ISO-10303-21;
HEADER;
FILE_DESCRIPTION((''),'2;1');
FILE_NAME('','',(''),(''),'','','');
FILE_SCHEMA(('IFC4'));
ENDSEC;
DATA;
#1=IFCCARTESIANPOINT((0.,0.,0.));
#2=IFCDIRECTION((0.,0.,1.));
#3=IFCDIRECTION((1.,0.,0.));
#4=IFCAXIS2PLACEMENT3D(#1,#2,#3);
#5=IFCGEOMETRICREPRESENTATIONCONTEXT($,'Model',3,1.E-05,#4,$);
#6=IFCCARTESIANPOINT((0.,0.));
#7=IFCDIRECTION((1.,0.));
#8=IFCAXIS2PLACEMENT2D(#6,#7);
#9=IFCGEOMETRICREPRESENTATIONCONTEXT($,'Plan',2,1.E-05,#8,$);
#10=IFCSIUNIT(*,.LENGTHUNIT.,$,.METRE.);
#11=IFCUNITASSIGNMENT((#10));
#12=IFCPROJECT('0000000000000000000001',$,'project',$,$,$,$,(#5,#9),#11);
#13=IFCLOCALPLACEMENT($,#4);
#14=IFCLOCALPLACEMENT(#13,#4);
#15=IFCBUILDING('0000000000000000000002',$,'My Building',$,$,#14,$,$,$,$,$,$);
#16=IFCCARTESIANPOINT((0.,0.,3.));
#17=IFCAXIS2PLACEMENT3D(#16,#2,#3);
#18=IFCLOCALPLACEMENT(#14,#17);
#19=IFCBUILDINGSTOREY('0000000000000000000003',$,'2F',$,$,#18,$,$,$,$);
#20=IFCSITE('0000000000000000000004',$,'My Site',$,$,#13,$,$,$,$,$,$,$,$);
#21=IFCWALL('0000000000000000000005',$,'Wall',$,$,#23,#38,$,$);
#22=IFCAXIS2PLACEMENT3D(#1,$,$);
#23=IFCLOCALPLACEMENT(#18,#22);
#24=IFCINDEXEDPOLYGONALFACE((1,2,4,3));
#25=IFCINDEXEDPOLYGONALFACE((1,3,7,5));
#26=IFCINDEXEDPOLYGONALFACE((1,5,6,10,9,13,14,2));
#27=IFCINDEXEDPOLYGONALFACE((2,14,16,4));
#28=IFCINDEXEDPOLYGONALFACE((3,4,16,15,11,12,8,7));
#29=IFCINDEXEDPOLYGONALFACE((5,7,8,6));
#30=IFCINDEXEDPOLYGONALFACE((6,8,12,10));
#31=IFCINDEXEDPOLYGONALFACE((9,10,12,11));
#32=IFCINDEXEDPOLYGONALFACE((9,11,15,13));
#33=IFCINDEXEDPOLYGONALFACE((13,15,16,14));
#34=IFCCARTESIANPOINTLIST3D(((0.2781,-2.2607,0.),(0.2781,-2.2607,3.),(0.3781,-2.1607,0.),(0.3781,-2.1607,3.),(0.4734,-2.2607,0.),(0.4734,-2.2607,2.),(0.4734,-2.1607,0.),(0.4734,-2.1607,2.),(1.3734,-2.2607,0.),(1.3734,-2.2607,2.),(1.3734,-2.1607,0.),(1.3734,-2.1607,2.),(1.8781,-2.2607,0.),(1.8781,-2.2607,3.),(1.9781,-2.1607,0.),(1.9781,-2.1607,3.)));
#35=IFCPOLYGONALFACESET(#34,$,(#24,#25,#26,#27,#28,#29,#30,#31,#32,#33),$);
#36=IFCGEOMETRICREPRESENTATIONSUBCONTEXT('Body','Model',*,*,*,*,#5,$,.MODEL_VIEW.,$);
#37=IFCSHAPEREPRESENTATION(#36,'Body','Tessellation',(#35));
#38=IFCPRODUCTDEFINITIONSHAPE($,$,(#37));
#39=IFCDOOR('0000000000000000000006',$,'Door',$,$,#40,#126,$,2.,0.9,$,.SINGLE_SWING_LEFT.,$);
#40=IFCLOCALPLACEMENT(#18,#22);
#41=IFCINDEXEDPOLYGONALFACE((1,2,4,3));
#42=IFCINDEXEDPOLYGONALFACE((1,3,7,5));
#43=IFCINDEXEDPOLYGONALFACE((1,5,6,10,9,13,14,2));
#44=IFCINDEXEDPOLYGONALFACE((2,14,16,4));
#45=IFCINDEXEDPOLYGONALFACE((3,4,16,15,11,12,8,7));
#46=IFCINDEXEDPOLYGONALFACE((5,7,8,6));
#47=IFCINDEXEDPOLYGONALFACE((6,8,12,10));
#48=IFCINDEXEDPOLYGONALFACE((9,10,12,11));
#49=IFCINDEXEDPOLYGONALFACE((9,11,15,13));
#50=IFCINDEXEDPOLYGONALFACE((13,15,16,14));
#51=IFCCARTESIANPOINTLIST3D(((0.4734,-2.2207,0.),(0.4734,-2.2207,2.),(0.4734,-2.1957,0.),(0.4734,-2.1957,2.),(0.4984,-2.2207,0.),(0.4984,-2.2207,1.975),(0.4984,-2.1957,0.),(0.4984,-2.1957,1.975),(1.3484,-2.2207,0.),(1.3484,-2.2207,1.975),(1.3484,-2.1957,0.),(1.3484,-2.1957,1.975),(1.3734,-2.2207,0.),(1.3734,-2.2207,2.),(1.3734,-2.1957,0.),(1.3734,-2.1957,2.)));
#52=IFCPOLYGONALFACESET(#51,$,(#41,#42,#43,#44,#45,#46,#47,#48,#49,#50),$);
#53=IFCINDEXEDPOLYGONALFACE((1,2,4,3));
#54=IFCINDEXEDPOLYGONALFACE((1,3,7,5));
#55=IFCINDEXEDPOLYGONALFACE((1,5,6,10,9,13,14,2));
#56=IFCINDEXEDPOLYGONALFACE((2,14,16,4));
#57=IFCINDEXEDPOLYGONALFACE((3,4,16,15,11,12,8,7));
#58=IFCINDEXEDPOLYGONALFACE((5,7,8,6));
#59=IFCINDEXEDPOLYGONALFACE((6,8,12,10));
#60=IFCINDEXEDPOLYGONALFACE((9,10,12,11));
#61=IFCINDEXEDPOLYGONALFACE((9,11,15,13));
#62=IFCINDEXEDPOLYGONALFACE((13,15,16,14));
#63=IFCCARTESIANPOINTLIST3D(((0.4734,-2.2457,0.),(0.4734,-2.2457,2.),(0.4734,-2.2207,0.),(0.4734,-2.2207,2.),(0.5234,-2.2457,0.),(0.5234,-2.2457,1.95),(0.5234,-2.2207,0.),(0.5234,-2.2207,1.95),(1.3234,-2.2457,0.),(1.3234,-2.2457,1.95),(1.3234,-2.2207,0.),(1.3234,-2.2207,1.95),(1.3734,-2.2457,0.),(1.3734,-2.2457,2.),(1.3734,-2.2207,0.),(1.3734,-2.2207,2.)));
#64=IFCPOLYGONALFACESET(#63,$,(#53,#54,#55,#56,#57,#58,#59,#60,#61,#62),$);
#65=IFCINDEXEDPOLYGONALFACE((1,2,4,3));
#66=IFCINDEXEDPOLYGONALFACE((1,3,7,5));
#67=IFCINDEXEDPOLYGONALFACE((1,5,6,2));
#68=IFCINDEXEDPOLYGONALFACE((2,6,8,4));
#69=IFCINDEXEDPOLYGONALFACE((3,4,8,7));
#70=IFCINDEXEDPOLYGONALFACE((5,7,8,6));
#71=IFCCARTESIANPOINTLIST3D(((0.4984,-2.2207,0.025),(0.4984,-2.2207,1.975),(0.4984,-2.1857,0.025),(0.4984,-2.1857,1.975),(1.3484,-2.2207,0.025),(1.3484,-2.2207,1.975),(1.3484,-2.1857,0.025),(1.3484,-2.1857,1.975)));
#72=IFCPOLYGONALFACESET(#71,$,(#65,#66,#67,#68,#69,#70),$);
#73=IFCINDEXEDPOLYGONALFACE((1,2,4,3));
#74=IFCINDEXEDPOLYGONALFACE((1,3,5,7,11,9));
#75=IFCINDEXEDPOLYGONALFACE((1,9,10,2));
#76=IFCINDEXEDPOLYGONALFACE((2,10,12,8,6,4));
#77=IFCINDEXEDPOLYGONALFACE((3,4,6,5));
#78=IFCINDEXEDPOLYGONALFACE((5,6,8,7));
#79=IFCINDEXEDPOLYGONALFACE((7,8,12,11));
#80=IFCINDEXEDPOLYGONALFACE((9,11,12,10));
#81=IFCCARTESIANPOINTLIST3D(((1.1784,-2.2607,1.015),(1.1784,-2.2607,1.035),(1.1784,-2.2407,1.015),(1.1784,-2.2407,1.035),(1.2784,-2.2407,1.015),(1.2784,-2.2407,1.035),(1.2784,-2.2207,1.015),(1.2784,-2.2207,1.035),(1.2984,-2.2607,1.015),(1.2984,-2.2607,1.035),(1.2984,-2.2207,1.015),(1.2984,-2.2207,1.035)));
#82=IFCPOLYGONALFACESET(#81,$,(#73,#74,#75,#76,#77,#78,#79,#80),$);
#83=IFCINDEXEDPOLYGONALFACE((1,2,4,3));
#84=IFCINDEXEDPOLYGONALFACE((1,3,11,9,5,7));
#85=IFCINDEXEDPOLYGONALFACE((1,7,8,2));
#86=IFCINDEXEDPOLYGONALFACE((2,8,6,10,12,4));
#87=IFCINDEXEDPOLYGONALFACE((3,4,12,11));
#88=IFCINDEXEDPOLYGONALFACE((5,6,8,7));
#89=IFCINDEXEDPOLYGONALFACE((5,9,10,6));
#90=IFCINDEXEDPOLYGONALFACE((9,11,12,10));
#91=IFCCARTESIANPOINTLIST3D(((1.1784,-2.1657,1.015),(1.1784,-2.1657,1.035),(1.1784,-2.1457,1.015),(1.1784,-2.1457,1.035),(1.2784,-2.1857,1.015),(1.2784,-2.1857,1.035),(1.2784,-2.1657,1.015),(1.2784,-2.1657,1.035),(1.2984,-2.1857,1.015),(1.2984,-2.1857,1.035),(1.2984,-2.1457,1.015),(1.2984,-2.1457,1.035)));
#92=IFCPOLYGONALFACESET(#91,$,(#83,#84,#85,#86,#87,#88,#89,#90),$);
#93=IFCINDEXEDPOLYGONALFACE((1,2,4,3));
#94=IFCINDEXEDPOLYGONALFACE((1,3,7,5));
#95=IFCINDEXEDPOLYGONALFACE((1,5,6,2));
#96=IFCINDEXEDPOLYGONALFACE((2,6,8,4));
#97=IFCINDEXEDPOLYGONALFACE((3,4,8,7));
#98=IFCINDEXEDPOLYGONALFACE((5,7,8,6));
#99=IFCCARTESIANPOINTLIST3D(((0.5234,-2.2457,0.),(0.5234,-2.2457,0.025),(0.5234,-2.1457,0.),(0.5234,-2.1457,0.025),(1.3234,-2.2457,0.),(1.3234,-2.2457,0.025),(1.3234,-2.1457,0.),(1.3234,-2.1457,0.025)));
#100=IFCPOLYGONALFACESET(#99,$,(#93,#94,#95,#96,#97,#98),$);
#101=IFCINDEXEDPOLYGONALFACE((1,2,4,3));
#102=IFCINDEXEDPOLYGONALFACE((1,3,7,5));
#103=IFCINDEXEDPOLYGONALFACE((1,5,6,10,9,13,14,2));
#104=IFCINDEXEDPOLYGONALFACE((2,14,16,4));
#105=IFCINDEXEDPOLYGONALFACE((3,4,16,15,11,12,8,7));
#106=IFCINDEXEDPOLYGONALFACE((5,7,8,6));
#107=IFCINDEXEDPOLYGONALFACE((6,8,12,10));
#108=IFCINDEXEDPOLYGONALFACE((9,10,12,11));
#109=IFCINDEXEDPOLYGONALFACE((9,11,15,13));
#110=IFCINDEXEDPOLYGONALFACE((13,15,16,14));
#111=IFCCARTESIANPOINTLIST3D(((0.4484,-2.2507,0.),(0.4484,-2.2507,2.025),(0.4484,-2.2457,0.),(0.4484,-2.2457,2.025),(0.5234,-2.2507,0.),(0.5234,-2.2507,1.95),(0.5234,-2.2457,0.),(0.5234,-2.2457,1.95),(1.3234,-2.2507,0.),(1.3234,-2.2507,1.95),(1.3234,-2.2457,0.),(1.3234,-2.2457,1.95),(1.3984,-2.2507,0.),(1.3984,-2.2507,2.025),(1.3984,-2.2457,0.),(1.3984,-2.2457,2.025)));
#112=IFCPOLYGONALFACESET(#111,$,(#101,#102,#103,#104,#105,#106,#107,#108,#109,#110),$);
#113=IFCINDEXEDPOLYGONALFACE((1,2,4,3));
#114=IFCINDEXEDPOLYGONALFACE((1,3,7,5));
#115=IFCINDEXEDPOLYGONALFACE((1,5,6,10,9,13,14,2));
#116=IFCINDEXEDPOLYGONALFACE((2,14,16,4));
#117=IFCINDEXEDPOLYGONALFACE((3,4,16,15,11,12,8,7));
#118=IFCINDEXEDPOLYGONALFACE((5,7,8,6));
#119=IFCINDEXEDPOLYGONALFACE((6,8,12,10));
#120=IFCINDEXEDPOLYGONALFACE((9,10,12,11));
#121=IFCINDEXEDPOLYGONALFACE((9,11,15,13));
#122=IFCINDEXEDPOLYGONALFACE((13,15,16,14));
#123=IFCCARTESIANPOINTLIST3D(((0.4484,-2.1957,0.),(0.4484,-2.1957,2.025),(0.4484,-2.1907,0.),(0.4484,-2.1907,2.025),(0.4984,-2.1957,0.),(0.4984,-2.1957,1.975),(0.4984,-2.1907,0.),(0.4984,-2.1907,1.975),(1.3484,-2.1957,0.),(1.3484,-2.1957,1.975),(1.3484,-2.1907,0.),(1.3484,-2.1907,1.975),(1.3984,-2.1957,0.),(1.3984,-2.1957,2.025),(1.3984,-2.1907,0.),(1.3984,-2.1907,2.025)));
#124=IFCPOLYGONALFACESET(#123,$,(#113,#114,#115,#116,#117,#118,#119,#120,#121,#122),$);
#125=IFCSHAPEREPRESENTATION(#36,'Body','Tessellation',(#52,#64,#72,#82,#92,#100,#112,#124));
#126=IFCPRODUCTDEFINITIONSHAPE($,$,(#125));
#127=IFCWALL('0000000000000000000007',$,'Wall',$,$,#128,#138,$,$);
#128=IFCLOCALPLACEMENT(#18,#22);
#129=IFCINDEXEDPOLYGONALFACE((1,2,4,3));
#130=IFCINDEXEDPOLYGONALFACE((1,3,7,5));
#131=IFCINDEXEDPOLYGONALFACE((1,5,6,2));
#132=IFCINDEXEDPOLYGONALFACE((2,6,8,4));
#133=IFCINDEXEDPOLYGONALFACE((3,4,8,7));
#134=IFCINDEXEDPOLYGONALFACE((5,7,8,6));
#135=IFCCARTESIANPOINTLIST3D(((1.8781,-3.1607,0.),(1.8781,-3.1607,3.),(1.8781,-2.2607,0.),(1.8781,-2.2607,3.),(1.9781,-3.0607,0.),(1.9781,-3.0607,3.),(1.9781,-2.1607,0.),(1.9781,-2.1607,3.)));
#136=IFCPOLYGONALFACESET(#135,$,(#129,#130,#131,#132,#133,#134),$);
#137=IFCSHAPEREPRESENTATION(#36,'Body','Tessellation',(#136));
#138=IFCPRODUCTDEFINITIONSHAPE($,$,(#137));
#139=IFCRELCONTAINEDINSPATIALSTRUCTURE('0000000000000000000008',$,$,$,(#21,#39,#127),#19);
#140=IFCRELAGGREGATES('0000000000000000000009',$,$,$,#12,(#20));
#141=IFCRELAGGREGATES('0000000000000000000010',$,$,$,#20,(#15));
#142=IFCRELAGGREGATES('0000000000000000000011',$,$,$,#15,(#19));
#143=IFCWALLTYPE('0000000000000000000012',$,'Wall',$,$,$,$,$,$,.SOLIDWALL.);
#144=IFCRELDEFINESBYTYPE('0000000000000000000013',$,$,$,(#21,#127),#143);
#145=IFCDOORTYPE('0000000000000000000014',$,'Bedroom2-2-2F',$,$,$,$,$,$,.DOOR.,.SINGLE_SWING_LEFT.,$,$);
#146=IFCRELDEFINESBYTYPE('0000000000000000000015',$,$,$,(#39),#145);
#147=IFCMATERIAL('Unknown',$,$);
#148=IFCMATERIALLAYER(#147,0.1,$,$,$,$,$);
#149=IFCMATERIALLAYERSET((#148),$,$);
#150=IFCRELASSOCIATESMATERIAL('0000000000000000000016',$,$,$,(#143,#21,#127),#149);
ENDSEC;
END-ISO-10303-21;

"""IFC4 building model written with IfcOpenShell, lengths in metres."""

from ifc_helpers import new_model, entity, si_unit, frame, origin_with_axes, origin_2d_with_axis, place, context, subcontext, project, spatial, line, indexed_curve, outline, extrude, shape, source, transform, mapped, material, layer, layer_set, layer_usage, type_object, type_shapes, element, fill, save


model = new_model("IFC4")

# Units and contexts
model_context = context("Model", 3, precision=1e-05, world=origin_with_axes())
plan_context = context("Plan", 2, precision=1e-05, world=origin_2d_with_axis())
body_context_1 = subcontext(model_context, "Body", "Model", "MODEL_VIEW")
body_context_2 = subcontext(plan_context, "Body", "Plan", "PLAN_VIEW")
ifc_project = project(units=[si_unit("LENGTHUNIT", "METRE")], contexts=[model_context, plan_context])

# Site, building, storey
site_placement = place(None, origin_with_axes())
site = spatial("IfcSite", under=ifc_project, at=site_placement, Name="My Site")
building_placement = place(site_placement, origin_with_axes())
building = spatial("IfcBuilding", under=site, at=building_placement, Name="My Building")
storey_placement = place(building_placement, frame((0.0, 0.0, 3.0), z_axis=(0.0, 0.0, 1.0), x_axis=(1.0, 0.0, 0.0)))
storey = spatial("IfcBuildingStorey", under=building, at=storey_placement, Name="2F")

# Shared definitions
ifc_material = material(Name="Unknown")

# Shared definitions
ifc_layer_1 = layer(ifc_material, 0.1)
ifc_layer_set_1 = layer_set([ifc_layer_1])
wall_type = type_object("IfcWallType", Name="Wall", PredefinedType="SOLIDWALL", material=ifc_layer_set_1)

# Wall, opening, door
ifc_layer_usage_1 = layer_usage(ifc_layer_set_1, "AXIS2", "POSITIVE", 0.0)
wall_1_placement = place(storey_placement, frame((0.2781, -2.2607, 0.0), z_axis=(0.0, 0.0, 1.0), x_axis=(1.0, 0.0, 0.0)))
wall_1 = element("IfcWall", 1, at=wall_1_placement, inside=storey, type_object=wall_type, material=ifc_layer_usage_1, Name="Wall", context=body_context_1, shape_type="SweptSolid", body=[
    extrude(outline(indexed_curve([(0.0, 0.0), (0.1, 0.1), (1.7, 0.1), (1.6, 0.0)], segments=[line(1, 2, 3, 4, 1)])), origin_with_axes(), (0.0, 0.0, 1.0), 3.0),
])
shared_shape_1 = source(origin_with_axes(), body_context_1, "Body", "SweptSolid", [
    extrude(outline(indexed_curve([(0.0, 0.0), (0.9, 0.0), (0.9, 2.0), (0.0, 2.0)], segments=[line(1, 2, 3, 4, 1)])), frame((0.0, -0.6, 0.0), z_axis=(0.0, -1.0, 0.0), x_axis=(1.0, 0.0, 0.0)), (0.0, 0.0, -1.0), 1.2),
])
opening_1_placement = place(wall_1_placement, frame((0.1952, 0.015, 0.0), z_axis=(0.0, 0.0, 1.0), x_axis=(1.0, 0.0, 0.0)))
opening_1 = element("IfcOpeningElement", 2, at=opening_1_placement, cuts=wall_1, PredefinedType="OPENING", context=body_context_1, shape_type="MappedRepresentation", body=[
    mapped(shared_shape_1, transform((0.0, 0.0, 0.0), x_axis=(1.0, 0.0, 0.0), y_axis=(0.0, 1.0, 0.0), z_axis=(0.0, 0.0, 1.0), scale=1.0)),
])
door_type_1 = type_object("IfcDoorType", Name="Bedroom2-2-2F", OperationType="SINGLE_SWING_LEFT", PredefinedType="DOOR")
shared_shape_2 = source(origin_with_axes(), body_context_1, "Body", "SweptSolid", [
    extrude(outline(indexed_curve([(0.0, 0.0), (0.0, 2.0), (0.9, 2.0), (0.9, 0.0), (0.875, 0.0), (0.875, 1.975), (0.025, 1.975), (0.025, 0.0)], segments=[line(1, 2, 3, 4, 5, 6, 7, 8, 1)])), frame((0.0, 0.025, 0.0), z_axis=(0.0, -1.0, 0.0), x_axis=(1.0, 0.0, 0.0)), (0.0, 0.0, -1.0), 0.025),
    extrude(outline(indexed_curve([(0.0, 0.0), (0.0, 2.0), (0.9, 2.0), (0.9, 0.0), (0.85, 0.0), (0.85, 1.95), (0.05, 1.95), (0.05, 0.0)], segments=[line(1, 2, 3, 4, 5, 6, 7, 8, 1)])), frame((0.0, 0.0, 0.0), z_axis=(0.0, -1.0, 0.0), x_axis=(1.0, 0.0, 0.0)), (0.0, 0.0, -1.0), 0.025),
    extrude(outline(indexed_curve([(0.0, 0.0), (0.85, 0.0), (0.85, 0.035), (0.0, 0.035)], segments=[line(1, 2, 3, 4, 1)])), frame((0.025, 0.025, 0.025), z_axis=(0.0, 0.0, 1.0), x_axis=(1.0, 0.0, 0.0)), (0.0, 0.0, 1.0), 1.95),
    extrude(outline(indexed_curve([(0.0, 0.0), (0.0, -0.04), (-0.12, -0.04), (-0.12, -0.02), (-0.02, -0.02), (-0.02, 0.0)], segments=[line(1, 2, 3, 4, 5, 6, 1)])), frame((0.825, 0.025, 1.015), z_axis=(0.0, 0.0, 1.0), x_axis=(1.0, 0.0, 0.0)), (0.0, 0.0, 1.0), 0.02),
    extrude(outline(indexed_curve([(0.0, 0.0), (0.0, 0.04), (-0.12, 0.04), (-0.12, 0.02), (-0.02, 0.02), (-0.02, 0.0)], segments=[line(1, 2, 3, 4, 5, 6, 1)])), frame((0.825, 0.06, 1.015), z_axis=(0.0, 0.0, 1.0), x_axis=(1.0, 0.0, 0.0)), (0.0, 0.0, 1.0), 0.02),
    extrude(outline(indexed_curve([(0.0, 0.0), (0.8, 0.0), (0.8, 0.1), (0.0, 0.1)], segments=[line(1, 2, 3, 4, 1)])), frame((0.05, 0.0, 0.0), z_axis=(0.0, 0.0, 1.0), x_axis=(1.0, 0.0, 0.0)), (0.0, 0.0, 1.0), 0.025),
    extrude(outline(indexed_curve([(0.0, 0.0), (0.0, 2.025), (0.95, 2.025), (0.95, 0.0), (0.875, 0.0), (0.875, 1.95), (0.075, 1.95), (0.075, 0.0)], segments=[line(1, 2, 3, 4, 5, 6, 7, 8, 1)])), frame((-0.025, -0.005, 0.0), z_axis=(0.0, -1.0, 0.0), x_axis=(1.0, 0.0, 0.0)), (0.0, 0.0, -1.0), 0.005),
    extrude(outline(indexed_curve([(0.0, 0.0), (0.0, 2.025), (0.95, 2.025), (0.95, 0.0), (0.9, 0.0), (0.9, 1.975), (0.05, 1.975), (0.05, 0.0)], segments=[line(1, 2, 3, 4, 5, 6, 7, 8, 1)])), frame((-0.025, 0.05, 0.0), z_axis=(0.0, -1.0, 0.0), x_axis=(1.0, 0.0, 0.0)), (0.0, 0.0, -1.0), 0.005),
])
shared_shape_3 = source(origin_with_axes(), body_context_2, "Body", "Curve2D", [
    entity("IfcIndexedPolyCurve", entity("IfcCartesianPointList2D", [[0.0, 0.0], [0.0, 0.05], [0.025, 0.05], [0.025, 0.025], [0.05, 0.025], [0.05, 0.0]]), [entity("IfcLineIndex", [1, 2, 3, 4, 5, 6, 1])]),
    entity("IfcIndexedPolyCurve", entity("IfcCartesianPointList2D", [[0.9, 0.0], [0.9, 0.05], [0.875, 0.05], [0.875, 0.025], [0.85, 0.025], [0.85, 0.0]]), [entity("IfcLineIndex", [1, 2, 3, 4, 5, 6, 1])]),
    entity("IfcTrimmedCurve", entity("IfcEllipse", entity("IfcAxis2Placement2D", entity("IfcCartesianPoint", [0.06, 0.05]), entity("IfcDirection", [1.0, 0.0])), 0.815, 0.85), [entity("IfcCartesianPoint", [0.875, 0.05])], [entity("IfcCartesianPoint", [0.06, 0.9])], True, "CARTESIAN"),
    entity("IfcIndexedPolyCurve", entity("IfcCartesianPointList2D", [[0.025, 0.05], [0.06, 0.05], [0.06, 0.9], [0.025, 0.9]]), [entity("IfcLineIndex", [1, 2, 3, 4, 1])]),
])
type_shapes(door_type_1, [shared_shape_2, shared_shape_3])
door_1_placement = place(opening_1_placement, frame((0.0, 0.0, 0.0), z_axis=(0.0, 0.0, 1.0), x_axis=(1.0, 0.0, 0.0)))
door_1 = element("IfcDoor", 3, at=door_1_placement, inside=storey, type_object=door_type_1, Name="Door", OperationType="SINGLE_SWING_LEFT", OverallHeight=2.0, OverallWidth=0.9, shapes=[
    shape(body_context_1, "Body", "MappedRepresentation", [mapped(shared_shape_2, transform((0.0, 0.0, 0.0), x_axis=(1.0, 0.0, 0.0), y_axis=(0.0, 1.0, 0.0), z_axis=(0.0, 0.0, 1.0), scale=1.0))]),
    shape(body_context_2, "Body", "MappedRepresentation", [mapped(shared_shape_3, transform((0.0, 0.0, 0.0), x_axis=(1.0, 0.0, 0.0), y_axis=(0.0, 1.0, 0.0), z_axis=(0.0, 0.0, 1.0), scale=1.0))]),
])
fill(opening_1, door_1)

# Wall
ifc_layer_usage_2 = layer_usage(ifc_layer_set_1, "AXIS2", "POSITIVE", 0.0)
wall_2_placement = place(storey_placement, frame((1.8781, -2.2607, 0.0), z_axis=(0.0, 0.0, 1.0), x_axis=(0.0, -1.0, 0.0)))
element("IfcWall", 4, at=wall_2_placement, inside=storey, type_object=wall_type, material=ifc_layer_usage_2, Name="Wall", context=body_context_1, shape_type="SweptSolid", body=[
    extrude(outline(indexed_curve([(0.0, 0.0), (-0.1, 0.1), (0.8, 0.1), (0.9, 0.0)], segments=[line(1, 2, 3, 4, 1)])), origin_with_axes(), (0.0, 0.0, 1.0), 3.0),
])

save(model, "model.ifc")
